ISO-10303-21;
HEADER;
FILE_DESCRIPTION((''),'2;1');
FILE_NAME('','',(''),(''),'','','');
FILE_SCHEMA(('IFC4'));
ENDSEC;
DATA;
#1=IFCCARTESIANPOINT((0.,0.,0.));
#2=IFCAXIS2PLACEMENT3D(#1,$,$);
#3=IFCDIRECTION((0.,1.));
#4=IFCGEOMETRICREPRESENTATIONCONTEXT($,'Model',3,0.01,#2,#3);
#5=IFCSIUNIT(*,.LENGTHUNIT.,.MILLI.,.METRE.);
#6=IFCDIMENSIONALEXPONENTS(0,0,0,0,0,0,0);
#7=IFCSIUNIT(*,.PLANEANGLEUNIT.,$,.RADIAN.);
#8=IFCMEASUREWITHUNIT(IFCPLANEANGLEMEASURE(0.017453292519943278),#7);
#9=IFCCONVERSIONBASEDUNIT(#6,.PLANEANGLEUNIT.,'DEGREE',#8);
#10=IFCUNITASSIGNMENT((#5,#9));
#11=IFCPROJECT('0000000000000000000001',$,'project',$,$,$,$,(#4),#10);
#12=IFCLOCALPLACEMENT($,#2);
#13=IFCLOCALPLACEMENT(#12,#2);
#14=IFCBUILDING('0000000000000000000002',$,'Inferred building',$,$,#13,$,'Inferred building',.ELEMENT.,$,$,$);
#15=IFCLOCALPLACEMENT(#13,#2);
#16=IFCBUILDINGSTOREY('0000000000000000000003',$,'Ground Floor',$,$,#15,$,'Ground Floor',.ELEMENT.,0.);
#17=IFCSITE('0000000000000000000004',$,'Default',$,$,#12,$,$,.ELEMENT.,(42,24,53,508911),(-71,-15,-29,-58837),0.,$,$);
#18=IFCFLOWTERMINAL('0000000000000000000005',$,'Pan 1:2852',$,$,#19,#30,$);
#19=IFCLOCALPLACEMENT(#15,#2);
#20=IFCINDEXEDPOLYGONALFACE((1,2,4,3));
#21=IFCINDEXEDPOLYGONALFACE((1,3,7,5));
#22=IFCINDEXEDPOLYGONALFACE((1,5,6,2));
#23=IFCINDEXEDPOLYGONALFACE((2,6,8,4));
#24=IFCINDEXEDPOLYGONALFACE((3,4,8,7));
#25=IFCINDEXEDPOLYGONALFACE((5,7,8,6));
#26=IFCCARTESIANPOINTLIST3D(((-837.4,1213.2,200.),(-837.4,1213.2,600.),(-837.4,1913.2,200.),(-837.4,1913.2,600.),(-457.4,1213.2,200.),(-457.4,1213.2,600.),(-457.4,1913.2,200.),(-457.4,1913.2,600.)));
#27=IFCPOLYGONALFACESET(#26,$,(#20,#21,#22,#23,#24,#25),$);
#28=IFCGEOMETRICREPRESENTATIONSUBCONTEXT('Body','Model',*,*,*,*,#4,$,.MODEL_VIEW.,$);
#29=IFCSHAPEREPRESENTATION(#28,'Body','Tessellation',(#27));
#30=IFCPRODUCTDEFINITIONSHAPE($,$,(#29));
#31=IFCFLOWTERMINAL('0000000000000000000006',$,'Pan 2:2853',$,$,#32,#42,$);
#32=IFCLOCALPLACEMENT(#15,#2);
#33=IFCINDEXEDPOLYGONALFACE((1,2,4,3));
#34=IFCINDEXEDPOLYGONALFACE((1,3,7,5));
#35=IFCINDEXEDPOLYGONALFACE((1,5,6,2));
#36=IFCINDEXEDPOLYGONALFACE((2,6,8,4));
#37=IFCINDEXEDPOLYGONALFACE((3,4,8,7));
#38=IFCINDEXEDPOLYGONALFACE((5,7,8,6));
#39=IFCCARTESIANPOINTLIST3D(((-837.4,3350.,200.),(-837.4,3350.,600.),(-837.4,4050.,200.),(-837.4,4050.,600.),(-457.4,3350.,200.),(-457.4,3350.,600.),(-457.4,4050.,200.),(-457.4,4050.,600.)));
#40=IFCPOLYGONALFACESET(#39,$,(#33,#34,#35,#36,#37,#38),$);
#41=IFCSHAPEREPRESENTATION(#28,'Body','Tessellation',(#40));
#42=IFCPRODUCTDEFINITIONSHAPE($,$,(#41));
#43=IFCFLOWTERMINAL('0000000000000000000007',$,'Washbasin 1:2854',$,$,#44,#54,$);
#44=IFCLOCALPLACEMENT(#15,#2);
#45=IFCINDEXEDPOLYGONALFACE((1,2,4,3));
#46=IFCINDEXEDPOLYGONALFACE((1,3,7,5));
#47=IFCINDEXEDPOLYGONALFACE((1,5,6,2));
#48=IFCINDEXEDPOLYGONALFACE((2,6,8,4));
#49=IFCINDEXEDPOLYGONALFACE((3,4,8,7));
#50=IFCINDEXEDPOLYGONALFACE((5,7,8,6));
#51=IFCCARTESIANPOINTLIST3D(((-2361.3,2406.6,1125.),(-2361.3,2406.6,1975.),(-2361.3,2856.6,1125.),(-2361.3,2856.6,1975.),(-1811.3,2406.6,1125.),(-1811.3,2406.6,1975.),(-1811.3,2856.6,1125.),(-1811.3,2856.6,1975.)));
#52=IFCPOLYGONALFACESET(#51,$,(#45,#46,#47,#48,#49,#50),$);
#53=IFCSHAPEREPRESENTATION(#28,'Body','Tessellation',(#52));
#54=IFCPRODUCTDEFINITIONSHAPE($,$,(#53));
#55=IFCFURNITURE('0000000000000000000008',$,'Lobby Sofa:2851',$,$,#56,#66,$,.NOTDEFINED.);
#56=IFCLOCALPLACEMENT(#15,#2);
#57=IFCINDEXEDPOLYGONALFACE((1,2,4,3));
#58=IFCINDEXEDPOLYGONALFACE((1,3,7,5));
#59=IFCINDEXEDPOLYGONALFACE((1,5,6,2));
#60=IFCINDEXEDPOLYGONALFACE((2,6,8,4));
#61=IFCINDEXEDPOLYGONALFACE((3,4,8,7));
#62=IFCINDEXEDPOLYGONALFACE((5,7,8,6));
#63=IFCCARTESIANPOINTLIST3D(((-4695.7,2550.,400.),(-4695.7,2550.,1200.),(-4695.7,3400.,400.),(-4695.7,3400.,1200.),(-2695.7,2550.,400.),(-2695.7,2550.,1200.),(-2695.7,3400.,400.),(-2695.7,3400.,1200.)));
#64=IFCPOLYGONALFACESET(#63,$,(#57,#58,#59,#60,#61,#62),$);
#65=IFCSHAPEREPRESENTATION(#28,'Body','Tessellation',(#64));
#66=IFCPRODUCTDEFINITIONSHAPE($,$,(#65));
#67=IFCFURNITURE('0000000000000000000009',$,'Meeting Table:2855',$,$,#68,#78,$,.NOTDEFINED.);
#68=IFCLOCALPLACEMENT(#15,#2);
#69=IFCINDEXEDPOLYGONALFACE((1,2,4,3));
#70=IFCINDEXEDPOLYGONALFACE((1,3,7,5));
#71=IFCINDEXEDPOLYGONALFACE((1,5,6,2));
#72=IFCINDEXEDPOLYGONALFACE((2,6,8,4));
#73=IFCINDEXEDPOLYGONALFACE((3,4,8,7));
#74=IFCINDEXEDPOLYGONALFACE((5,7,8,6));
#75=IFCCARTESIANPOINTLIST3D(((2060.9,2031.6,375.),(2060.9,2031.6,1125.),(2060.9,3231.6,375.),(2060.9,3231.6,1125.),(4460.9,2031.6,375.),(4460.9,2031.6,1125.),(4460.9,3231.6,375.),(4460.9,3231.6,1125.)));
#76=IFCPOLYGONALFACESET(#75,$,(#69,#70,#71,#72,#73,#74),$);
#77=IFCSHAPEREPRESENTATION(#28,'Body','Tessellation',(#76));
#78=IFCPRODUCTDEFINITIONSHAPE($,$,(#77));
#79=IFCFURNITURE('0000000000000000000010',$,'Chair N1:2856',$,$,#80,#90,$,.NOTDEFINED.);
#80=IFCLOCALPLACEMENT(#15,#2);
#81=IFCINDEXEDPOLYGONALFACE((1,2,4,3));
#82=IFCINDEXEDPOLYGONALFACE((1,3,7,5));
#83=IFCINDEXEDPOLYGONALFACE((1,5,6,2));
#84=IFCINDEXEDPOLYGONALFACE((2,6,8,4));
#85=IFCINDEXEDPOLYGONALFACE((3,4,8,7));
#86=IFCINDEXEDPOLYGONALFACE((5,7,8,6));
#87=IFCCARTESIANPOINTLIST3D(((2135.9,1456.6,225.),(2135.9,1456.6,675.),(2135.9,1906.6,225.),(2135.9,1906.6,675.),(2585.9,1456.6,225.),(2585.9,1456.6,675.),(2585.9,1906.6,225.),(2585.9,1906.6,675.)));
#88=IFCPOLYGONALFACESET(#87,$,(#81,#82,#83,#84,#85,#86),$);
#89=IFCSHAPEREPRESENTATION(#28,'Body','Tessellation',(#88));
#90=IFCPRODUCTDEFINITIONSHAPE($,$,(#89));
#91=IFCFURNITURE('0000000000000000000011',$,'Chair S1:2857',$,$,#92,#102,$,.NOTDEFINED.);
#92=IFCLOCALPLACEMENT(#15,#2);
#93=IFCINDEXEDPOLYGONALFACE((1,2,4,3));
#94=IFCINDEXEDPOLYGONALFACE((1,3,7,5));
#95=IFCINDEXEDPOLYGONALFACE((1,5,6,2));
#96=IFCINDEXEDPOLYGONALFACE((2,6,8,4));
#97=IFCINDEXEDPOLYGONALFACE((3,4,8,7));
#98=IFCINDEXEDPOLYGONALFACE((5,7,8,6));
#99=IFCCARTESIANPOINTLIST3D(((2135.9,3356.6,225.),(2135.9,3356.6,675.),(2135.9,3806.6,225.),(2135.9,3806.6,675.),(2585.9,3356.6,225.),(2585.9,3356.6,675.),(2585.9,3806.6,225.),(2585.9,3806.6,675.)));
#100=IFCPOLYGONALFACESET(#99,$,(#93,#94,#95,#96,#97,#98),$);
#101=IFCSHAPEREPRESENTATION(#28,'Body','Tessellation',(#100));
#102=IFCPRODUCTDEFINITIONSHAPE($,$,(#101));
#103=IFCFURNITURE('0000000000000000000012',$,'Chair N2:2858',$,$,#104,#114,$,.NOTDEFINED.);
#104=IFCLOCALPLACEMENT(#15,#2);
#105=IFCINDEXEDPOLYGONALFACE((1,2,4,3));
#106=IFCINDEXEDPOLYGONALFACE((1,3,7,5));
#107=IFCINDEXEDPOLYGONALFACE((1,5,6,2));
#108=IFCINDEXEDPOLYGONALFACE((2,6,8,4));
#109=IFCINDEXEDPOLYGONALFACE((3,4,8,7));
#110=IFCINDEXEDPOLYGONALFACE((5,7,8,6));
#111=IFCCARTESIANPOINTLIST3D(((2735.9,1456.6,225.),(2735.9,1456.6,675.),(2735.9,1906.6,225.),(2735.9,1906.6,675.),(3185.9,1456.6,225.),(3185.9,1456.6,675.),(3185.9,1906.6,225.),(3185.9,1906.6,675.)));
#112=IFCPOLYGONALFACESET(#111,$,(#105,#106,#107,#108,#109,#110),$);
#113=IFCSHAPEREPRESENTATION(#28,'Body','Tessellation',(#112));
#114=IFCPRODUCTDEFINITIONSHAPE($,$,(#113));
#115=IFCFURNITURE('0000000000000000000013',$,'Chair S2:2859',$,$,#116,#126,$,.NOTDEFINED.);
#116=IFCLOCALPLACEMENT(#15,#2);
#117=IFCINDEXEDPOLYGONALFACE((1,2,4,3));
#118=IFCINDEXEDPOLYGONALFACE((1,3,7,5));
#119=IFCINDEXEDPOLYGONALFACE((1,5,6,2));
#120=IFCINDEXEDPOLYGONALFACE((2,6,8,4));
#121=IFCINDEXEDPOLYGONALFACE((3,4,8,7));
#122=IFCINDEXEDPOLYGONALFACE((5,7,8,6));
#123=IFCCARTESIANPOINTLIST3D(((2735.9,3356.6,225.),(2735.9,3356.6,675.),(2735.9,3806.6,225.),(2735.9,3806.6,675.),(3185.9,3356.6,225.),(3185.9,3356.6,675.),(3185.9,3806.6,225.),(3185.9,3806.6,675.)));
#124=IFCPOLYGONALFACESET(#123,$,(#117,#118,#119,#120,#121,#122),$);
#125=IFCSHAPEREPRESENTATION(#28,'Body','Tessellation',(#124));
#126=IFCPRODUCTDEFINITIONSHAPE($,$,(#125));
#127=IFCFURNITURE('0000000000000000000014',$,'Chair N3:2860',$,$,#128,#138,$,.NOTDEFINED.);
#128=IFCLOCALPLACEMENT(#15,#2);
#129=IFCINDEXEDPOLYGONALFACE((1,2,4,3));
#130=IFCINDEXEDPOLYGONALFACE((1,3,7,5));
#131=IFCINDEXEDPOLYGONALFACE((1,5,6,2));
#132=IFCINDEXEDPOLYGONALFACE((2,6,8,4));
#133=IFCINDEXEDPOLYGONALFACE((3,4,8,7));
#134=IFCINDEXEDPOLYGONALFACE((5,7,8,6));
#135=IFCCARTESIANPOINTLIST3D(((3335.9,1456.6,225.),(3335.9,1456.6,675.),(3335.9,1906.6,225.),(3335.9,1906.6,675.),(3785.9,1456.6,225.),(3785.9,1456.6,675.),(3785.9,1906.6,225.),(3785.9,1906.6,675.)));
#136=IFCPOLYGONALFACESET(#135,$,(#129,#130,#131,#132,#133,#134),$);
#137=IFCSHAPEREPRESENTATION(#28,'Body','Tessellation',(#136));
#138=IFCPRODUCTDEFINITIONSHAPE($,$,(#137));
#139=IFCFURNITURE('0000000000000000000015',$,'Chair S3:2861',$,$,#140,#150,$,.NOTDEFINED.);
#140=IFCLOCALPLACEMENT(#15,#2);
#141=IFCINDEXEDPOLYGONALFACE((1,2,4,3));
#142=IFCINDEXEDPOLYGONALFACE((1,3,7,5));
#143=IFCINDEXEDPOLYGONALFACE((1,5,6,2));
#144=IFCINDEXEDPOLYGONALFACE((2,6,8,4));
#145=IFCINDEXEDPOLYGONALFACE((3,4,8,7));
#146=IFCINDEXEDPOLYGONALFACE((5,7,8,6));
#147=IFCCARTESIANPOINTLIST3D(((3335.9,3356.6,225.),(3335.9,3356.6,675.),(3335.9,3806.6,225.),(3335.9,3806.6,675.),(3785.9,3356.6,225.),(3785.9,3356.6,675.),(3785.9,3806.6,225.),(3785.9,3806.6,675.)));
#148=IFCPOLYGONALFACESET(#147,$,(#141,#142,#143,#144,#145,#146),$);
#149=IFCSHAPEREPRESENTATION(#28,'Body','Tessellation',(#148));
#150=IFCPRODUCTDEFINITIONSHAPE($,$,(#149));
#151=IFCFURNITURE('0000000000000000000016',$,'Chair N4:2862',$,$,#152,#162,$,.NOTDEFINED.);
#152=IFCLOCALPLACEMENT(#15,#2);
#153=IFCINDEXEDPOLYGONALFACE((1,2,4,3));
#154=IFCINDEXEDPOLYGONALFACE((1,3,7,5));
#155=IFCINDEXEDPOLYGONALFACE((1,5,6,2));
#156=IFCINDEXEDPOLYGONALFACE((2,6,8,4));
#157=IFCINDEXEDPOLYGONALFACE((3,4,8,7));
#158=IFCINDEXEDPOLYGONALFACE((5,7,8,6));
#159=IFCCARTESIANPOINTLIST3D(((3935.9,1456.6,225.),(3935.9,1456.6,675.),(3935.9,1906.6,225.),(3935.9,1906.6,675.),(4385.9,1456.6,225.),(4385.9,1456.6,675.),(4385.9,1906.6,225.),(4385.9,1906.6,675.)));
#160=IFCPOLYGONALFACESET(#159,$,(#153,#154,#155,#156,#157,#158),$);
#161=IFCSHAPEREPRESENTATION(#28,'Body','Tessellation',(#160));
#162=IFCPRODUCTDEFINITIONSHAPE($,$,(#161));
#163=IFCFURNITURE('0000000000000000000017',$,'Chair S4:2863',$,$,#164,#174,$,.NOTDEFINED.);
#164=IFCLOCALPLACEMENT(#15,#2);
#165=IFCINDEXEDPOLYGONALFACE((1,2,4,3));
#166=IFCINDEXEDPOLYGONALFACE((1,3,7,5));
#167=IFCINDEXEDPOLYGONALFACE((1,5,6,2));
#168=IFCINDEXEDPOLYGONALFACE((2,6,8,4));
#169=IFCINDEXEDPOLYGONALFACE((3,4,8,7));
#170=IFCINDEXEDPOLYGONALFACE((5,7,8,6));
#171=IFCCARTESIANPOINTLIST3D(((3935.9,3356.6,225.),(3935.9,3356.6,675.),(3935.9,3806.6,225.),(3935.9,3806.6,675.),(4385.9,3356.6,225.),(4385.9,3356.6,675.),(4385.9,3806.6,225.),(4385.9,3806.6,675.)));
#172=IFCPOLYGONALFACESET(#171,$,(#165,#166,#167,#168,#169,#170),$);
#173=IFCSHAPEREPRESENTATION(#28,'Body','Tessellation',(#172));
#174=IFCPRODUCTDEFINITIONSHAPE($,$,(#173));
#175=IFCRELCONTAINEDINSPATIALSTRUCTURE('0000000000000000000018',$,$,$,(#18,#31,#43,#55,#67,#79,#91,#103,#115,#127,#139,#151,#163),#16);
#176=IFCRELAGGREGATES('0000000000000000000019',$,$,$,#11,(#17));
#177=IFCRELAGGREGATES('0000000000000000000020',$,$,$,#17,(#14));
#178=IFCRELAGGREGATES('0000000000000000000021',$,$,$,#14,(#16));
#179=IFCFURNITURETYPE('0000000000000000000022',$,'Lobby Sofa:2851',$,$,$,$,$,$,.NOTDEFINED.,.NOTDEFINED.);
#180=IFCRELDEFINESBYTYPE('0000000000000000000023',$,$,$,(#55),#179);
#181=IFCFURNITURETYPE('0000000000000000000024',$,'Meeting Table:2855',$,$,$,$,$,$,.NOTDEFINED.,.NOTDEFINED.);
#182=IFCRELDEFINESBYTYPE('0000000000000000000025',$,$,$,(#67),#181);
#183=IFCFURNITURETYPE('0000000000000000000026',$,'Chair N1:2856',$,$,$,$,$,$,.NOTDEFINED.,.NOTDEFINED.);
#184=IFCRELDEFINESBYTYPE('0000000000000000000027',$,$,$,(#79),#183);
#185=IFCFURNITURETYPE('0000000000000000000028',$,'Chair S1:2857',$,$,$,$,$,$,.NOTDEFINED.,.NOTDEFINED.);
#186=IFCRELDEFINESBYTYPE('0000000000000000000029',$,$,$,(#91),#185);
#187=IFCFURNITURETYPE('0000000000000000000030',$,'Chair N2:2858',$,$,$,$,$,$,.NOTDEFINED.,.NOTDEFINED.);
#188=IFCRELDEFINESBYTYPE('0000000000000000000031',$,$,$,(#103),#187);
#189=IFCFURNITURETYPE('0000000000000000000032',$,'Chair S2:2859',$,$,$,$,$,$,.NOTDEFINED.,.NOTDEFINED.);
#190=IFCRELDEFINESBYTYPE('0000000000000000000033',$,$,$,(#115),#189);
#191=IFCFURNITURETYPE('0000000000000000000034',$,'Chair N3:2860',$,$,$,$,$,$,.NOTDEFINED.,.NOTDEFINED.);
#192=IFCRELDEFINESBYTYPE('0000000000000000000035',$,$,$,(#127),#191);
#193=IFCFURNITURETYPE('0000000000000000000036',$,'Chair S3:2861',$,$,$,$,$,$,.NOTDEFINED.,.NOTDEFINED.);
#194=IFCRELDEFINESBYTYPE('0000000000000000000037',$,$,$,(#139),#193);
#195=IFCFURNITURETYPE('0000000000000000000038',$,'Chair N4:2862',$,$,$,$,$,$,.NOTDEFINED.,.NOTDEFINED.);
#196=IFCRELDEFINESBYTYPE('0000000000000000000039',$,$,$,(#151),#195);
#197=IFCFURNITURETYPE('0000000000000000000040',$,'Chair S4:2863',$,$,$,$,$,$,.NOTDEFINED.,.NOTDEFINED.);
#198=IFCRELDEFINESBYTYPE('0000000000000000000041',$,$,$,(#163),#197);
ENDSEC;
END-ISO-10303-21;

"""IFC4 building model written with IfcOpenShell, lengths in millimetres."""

from ifc_helpers import new_model, entity, si_unit, converted_unit, direction, frame, frame_2d, origin, origin_2d_with_axis, place, context, subcontext, project, spatial, rectangle, extrude, type_object, element, save


model = new_model("IFC4")

# Units and contexts
model_context = context("Model", 3, precision=0.01, world=origin(), true_north=direction((0.0, 1.0)))
body_context = subcontext(model_context, "Body", "Model", "MODEL_VIEW")
ifc_project = project(units=[si_unit("LENGTHUNIT", "METRE", prefix="MILLI"), converted_unit("PLANEANGLEUNIT", "DEGREE", entity("IfcPlaneAngleMeasure", 0.017453292519943278), si_unit("PLANEANGLEUNIT", "RADIAN"), dimensions=[0, 0, 0, 0, 0, 0, 0])], contexts=[model_context])

# Site, building, storey
site_placement = place(None, origin())
site = spatial("IfcSite", under=ifc_project, at=site_placement, Name="Default", CompositionType="ELEMENT", RefLatitude=(42, 24, 53, 508911), RefLongitude=(-71, -15, -29, -58837), RefElevation=0.0)
building_placement = place(site_placement, origin())
building = spatial("IfcBuilding", under=site, at=building_placement, Name="Inferred building", LongName="Inferred building", CompositionType="ELEMENT")
storey_placement = place(building_placement, origin())
storey = spatial("IfcBuildingStorey", under=building, at=storey_placement, Name="Ground Floor", LongName="Ground Floor", CompositionType="ELEMENT", Elevation=0.0)

# Flow terminals
flow_terminal_1_placement = place(storey_placement, origin())
element("IfcFlowTerminal", 1, at=flow_terminal_1_placement, inside=storey, Name="Pan 1:2852", context=body_context, shape_type="SweptSolid", body=[
    extrude(rectangle(XDim=700.0, YDim=380.0, at=origin_2d_with_axis()), frame((-647.4, 1563.2, 200.0), z_axis=(0.0, 0.0, 1.0), x_axis=(0.0, 1.0, 0.0)), (0.0, 0.0, 1.0), 400.0),
])
flow_terminal_2_placement = place(storey_placement, origin())
element("IfcFlowTerminal", 2, at=flow_terminal_2_placement, inside=storey, Name="Pan 2:2853", context=body_context, shape_type="SweptSolid", body=[
    extrude(rectangle(XDim=700.0, YDim=380.0, at=origin_2d_with_axis()), frame((-647.4, 3700.0, 200.0), z_axis=(0.0, 0.0, 1.0), x_axis=(0.0, 1.0, 0.0)), (0.0, 0.0, 1.0), 400.0),
])
flow_terminal_3_placement = place(storey_placement, origin())
element("IfcFlowTerminal", 3, at=flow_terminal_3_placement, inside=storey, Name="Washbasin 1:2854", context=body_context, shape_type="SweptSolid", body=[
    extrude(rectangle(XDim=450.0, YDim=550.0, at=frame_2d((0.0, 0.0), x_axis=(1.0, 0.0))), frame((-2086.3, 2631.6, 1125.0), z_axis=(0.0, 0.0, 1.0), x_axis=(0.0, 1.0, 0.0)), (0.0, 0.0, 1.0), 850.0),
])

# Furniture
furniture_type_1 = type_object("IfcFurnitureType", Name="Lobby Sofa:2851", PredefinedType="NOTDEFINED")
furniture_1_placement = place(storey_placement, origin())
element("IfcFurniture", 4, at=furniture_1_placement, inside=storey, type_object=furniture_type_1, Name="Lobby Sofa:2851", PredefinedType="NOTDEFINED", context=body_context, shape_type="SweptSolid", body=[
    extrude(rectangle(XDim=2000.0, YDim=850.0, at=origin_2d_with_axis()), frame((-3695.7, 2975.0, 400.0)), (0.0, 0.0, 1.0), 800.0),
])
furniture_type_2 = type_object("IfcFurnitureType", Name="Meeting Table:2855", PredefinedType="NOTDEFINED")
furniture_2_placement = place(storey_placement, origin())
element("IfcFurniture", 5, at=furniture_2_placement, inside=storey, type_object=furniture_type_2, Name="Meeting Table:2855", PredefinedType="NOTDEFINED", context=body_context, shape_type="SweptSolid", body=[
    extrude(rectangle(XDim=2400.0, YDim=1200.0, at=origin_2d_with_axis()), frame((3260.9, 2631.6, 375.0)), (0.0, 0.0, 1.0), 750.0),
])
furniture_type_3 = type_object("IfcFurnitureType", Name="Chair N1:2856", PredefinedType="NOTDEFINED")
furniture_3_placement = place(storey_placement, origin())
element("IfcFurniture", 6, at=furniture_3_placement, inside=storey, type_object=furniture_type_3, Name="Chair N1:2856", PredefinedType="NOTDEFINED", context=body_context, shape_type="SweptSolid", body=[
    extrude(rectangle(XDim=450.0, YDim=450.0, at=frame_2d((0.0, 0.0), x_axis=(1.0, 0.0))), frame((2360.9, 1681.6, 225.0)), (0.0, 0.0, 1.0), 450.0),
])
furniture_type_4 = type_object("IfcFurnitureType", Name="Chair S1:2857", PredefinedType="NOTDEFINED")
furniture_4_placement = place(storey_placement, origin())
element("IfcFurniture", 7, at=furniture_4_placement, inside=storey, type_object=furniture_type_4, Name="Chair S1:2857", PredefinedType="NOTDEFINED", context=body_context, shape_type="SweptSolid", body=[
    extrude(rectangle(XDim=450.0, YDim=450.0, at=frame_2d((0.0, 0.0), x_axis=(1.0, 0.0))), frame((2360.9, 3581.6, 225.0)), (0.0, 0.0, 1.0), 450.0),
])
furniture_type_5 = type_object("IfcFurnitureType", Name="Chair N2:2858", PredefinedType="NOTDEFINED")
furniture_5_placement = place(storey_placement, origin())
element("IfcFurniture", 8, at=furniture_5_placement, inside=storey, type_object=furniture_type_5, Name="Chair N2:2858", PredefinedType="NOTDEFINED", context=body_context, shape_type="SweptSolid", body=[
    extrude(rectangle(XDim=450.0, YDim=450.0, at=origin_2d_with_axis()), frame((2960.9, 1681.6, 225.0)), (0.0, 0.0, 1.0), 450.0),
])
furniture_type_6 = type_object("IfcFurnitureType", Name="Chair S2:2859", PredefinedType="NOTDEFINED")
furniture_6_placement = place(storey_placement, origin())
element("IfcFurniture", 9, at=furniture_6_placement, inside=storey, type_object=furniture_type_6, Name="Chair S2:2859", PredefinedType="NOTDEFINED", context=body_context, shape_type="SweptSolid", body=[
    extrude(rectangle(XDim=450.0, YDim=450.0, at=frame_2d((0.0, 0.0), x_axis=(1.0, 0.0))), frame((2960.9, 3581.6, 225.0)), (0.0, 0.0, 1.0), 450.0),
])
furniture_type_7 = type_object("IfcFurnitureType", Name="Chair N3:2860", PredefinedType="NOTDEFINED")
furniture_7_placement = place(storey_placement, origin())
element("IfcFurniture", 10, at=furniture_7_placement, inside=storey, type_object=furniture_type_7, Name="Chair N3:2860", PredefinedType="NOTDEFINED", context=body_context, shape_type="SweptSolid", body=[
    extrude(rectangle(XDim=450.0, YDim=450.0, at=origin_2d_with_axis()), frame((3560.9, 1681.6, 225.0)), (0.0, 0.0, 1.0), 450.0),
])
furniture_type_8 = type_object("IfcFurnitureType", Name="Chair S3:2861", PredefinedType="NOTDEFINED")
furniture_8_placement = place(storey_placement, origin())
element("IfcFurniture", 11, at=furniture_8_placement, inside=storey, type_object=furniture_type_8, Name="Chair S3:2861", PredefinedType="NOTDEFINED", context=body_context, shape_type="SweptSolid", body=[
    extrude(rectangle(XDim=450.0, YDim=450.0, at=frame_2d((0.0, 0.0), x_axis=(1.0, 0.0))), frame((3560.9, 3581.6, 225.0)), (0.0, 0.0, 1.0), 450.0),
])
furniture_type_9 = type_object("IfcFurnitureType", Name="Chair N4:2862", PredefinedType="NOTDEFINED")
furniture_9_placement = place(storey_placement, origin())
element("IfcFurniture", 12, at=furniture_9_placement, inside=storey, type_object=furniture_type_9, Name="Chair N4:2862", PredefinedType="NOTDEFINED", context=body_context, shape_type="SweptSolid", body=[
    extrude(rectangle(XDim=450.0, YDim=450.0, at=origin_2d_with_axis()), frame((4160.9, 1681.6, 225.0)), (0.0, 0.0, 1.0), 450.0),
])
furniture_type_10 = type_object("IfcFurnitureType", Name="Chair S4:2863", PredefinedType="NOTDEFINED")
furniture_10_placement = place(storey_placement, origin())
element("IfcFurniture", 13, at=furniture_10_placement, inside=storey, type_object=furniture_type_10, Name="Chair S4:2863", PredefinedType="NOTDEFINED", context=body_context, shape_type="SweptSolid", body=[
    extrude(rectangle(XDim=450.0, YDim=450.0, at=frame_2d((0.0, 0.0), x_axis=(1.0, 0.0))), frame((4160.9, 3581.6, 225.0)), (0.0, 0.0, 1.0), 450.0),
])

save(model, "model.ifc")
